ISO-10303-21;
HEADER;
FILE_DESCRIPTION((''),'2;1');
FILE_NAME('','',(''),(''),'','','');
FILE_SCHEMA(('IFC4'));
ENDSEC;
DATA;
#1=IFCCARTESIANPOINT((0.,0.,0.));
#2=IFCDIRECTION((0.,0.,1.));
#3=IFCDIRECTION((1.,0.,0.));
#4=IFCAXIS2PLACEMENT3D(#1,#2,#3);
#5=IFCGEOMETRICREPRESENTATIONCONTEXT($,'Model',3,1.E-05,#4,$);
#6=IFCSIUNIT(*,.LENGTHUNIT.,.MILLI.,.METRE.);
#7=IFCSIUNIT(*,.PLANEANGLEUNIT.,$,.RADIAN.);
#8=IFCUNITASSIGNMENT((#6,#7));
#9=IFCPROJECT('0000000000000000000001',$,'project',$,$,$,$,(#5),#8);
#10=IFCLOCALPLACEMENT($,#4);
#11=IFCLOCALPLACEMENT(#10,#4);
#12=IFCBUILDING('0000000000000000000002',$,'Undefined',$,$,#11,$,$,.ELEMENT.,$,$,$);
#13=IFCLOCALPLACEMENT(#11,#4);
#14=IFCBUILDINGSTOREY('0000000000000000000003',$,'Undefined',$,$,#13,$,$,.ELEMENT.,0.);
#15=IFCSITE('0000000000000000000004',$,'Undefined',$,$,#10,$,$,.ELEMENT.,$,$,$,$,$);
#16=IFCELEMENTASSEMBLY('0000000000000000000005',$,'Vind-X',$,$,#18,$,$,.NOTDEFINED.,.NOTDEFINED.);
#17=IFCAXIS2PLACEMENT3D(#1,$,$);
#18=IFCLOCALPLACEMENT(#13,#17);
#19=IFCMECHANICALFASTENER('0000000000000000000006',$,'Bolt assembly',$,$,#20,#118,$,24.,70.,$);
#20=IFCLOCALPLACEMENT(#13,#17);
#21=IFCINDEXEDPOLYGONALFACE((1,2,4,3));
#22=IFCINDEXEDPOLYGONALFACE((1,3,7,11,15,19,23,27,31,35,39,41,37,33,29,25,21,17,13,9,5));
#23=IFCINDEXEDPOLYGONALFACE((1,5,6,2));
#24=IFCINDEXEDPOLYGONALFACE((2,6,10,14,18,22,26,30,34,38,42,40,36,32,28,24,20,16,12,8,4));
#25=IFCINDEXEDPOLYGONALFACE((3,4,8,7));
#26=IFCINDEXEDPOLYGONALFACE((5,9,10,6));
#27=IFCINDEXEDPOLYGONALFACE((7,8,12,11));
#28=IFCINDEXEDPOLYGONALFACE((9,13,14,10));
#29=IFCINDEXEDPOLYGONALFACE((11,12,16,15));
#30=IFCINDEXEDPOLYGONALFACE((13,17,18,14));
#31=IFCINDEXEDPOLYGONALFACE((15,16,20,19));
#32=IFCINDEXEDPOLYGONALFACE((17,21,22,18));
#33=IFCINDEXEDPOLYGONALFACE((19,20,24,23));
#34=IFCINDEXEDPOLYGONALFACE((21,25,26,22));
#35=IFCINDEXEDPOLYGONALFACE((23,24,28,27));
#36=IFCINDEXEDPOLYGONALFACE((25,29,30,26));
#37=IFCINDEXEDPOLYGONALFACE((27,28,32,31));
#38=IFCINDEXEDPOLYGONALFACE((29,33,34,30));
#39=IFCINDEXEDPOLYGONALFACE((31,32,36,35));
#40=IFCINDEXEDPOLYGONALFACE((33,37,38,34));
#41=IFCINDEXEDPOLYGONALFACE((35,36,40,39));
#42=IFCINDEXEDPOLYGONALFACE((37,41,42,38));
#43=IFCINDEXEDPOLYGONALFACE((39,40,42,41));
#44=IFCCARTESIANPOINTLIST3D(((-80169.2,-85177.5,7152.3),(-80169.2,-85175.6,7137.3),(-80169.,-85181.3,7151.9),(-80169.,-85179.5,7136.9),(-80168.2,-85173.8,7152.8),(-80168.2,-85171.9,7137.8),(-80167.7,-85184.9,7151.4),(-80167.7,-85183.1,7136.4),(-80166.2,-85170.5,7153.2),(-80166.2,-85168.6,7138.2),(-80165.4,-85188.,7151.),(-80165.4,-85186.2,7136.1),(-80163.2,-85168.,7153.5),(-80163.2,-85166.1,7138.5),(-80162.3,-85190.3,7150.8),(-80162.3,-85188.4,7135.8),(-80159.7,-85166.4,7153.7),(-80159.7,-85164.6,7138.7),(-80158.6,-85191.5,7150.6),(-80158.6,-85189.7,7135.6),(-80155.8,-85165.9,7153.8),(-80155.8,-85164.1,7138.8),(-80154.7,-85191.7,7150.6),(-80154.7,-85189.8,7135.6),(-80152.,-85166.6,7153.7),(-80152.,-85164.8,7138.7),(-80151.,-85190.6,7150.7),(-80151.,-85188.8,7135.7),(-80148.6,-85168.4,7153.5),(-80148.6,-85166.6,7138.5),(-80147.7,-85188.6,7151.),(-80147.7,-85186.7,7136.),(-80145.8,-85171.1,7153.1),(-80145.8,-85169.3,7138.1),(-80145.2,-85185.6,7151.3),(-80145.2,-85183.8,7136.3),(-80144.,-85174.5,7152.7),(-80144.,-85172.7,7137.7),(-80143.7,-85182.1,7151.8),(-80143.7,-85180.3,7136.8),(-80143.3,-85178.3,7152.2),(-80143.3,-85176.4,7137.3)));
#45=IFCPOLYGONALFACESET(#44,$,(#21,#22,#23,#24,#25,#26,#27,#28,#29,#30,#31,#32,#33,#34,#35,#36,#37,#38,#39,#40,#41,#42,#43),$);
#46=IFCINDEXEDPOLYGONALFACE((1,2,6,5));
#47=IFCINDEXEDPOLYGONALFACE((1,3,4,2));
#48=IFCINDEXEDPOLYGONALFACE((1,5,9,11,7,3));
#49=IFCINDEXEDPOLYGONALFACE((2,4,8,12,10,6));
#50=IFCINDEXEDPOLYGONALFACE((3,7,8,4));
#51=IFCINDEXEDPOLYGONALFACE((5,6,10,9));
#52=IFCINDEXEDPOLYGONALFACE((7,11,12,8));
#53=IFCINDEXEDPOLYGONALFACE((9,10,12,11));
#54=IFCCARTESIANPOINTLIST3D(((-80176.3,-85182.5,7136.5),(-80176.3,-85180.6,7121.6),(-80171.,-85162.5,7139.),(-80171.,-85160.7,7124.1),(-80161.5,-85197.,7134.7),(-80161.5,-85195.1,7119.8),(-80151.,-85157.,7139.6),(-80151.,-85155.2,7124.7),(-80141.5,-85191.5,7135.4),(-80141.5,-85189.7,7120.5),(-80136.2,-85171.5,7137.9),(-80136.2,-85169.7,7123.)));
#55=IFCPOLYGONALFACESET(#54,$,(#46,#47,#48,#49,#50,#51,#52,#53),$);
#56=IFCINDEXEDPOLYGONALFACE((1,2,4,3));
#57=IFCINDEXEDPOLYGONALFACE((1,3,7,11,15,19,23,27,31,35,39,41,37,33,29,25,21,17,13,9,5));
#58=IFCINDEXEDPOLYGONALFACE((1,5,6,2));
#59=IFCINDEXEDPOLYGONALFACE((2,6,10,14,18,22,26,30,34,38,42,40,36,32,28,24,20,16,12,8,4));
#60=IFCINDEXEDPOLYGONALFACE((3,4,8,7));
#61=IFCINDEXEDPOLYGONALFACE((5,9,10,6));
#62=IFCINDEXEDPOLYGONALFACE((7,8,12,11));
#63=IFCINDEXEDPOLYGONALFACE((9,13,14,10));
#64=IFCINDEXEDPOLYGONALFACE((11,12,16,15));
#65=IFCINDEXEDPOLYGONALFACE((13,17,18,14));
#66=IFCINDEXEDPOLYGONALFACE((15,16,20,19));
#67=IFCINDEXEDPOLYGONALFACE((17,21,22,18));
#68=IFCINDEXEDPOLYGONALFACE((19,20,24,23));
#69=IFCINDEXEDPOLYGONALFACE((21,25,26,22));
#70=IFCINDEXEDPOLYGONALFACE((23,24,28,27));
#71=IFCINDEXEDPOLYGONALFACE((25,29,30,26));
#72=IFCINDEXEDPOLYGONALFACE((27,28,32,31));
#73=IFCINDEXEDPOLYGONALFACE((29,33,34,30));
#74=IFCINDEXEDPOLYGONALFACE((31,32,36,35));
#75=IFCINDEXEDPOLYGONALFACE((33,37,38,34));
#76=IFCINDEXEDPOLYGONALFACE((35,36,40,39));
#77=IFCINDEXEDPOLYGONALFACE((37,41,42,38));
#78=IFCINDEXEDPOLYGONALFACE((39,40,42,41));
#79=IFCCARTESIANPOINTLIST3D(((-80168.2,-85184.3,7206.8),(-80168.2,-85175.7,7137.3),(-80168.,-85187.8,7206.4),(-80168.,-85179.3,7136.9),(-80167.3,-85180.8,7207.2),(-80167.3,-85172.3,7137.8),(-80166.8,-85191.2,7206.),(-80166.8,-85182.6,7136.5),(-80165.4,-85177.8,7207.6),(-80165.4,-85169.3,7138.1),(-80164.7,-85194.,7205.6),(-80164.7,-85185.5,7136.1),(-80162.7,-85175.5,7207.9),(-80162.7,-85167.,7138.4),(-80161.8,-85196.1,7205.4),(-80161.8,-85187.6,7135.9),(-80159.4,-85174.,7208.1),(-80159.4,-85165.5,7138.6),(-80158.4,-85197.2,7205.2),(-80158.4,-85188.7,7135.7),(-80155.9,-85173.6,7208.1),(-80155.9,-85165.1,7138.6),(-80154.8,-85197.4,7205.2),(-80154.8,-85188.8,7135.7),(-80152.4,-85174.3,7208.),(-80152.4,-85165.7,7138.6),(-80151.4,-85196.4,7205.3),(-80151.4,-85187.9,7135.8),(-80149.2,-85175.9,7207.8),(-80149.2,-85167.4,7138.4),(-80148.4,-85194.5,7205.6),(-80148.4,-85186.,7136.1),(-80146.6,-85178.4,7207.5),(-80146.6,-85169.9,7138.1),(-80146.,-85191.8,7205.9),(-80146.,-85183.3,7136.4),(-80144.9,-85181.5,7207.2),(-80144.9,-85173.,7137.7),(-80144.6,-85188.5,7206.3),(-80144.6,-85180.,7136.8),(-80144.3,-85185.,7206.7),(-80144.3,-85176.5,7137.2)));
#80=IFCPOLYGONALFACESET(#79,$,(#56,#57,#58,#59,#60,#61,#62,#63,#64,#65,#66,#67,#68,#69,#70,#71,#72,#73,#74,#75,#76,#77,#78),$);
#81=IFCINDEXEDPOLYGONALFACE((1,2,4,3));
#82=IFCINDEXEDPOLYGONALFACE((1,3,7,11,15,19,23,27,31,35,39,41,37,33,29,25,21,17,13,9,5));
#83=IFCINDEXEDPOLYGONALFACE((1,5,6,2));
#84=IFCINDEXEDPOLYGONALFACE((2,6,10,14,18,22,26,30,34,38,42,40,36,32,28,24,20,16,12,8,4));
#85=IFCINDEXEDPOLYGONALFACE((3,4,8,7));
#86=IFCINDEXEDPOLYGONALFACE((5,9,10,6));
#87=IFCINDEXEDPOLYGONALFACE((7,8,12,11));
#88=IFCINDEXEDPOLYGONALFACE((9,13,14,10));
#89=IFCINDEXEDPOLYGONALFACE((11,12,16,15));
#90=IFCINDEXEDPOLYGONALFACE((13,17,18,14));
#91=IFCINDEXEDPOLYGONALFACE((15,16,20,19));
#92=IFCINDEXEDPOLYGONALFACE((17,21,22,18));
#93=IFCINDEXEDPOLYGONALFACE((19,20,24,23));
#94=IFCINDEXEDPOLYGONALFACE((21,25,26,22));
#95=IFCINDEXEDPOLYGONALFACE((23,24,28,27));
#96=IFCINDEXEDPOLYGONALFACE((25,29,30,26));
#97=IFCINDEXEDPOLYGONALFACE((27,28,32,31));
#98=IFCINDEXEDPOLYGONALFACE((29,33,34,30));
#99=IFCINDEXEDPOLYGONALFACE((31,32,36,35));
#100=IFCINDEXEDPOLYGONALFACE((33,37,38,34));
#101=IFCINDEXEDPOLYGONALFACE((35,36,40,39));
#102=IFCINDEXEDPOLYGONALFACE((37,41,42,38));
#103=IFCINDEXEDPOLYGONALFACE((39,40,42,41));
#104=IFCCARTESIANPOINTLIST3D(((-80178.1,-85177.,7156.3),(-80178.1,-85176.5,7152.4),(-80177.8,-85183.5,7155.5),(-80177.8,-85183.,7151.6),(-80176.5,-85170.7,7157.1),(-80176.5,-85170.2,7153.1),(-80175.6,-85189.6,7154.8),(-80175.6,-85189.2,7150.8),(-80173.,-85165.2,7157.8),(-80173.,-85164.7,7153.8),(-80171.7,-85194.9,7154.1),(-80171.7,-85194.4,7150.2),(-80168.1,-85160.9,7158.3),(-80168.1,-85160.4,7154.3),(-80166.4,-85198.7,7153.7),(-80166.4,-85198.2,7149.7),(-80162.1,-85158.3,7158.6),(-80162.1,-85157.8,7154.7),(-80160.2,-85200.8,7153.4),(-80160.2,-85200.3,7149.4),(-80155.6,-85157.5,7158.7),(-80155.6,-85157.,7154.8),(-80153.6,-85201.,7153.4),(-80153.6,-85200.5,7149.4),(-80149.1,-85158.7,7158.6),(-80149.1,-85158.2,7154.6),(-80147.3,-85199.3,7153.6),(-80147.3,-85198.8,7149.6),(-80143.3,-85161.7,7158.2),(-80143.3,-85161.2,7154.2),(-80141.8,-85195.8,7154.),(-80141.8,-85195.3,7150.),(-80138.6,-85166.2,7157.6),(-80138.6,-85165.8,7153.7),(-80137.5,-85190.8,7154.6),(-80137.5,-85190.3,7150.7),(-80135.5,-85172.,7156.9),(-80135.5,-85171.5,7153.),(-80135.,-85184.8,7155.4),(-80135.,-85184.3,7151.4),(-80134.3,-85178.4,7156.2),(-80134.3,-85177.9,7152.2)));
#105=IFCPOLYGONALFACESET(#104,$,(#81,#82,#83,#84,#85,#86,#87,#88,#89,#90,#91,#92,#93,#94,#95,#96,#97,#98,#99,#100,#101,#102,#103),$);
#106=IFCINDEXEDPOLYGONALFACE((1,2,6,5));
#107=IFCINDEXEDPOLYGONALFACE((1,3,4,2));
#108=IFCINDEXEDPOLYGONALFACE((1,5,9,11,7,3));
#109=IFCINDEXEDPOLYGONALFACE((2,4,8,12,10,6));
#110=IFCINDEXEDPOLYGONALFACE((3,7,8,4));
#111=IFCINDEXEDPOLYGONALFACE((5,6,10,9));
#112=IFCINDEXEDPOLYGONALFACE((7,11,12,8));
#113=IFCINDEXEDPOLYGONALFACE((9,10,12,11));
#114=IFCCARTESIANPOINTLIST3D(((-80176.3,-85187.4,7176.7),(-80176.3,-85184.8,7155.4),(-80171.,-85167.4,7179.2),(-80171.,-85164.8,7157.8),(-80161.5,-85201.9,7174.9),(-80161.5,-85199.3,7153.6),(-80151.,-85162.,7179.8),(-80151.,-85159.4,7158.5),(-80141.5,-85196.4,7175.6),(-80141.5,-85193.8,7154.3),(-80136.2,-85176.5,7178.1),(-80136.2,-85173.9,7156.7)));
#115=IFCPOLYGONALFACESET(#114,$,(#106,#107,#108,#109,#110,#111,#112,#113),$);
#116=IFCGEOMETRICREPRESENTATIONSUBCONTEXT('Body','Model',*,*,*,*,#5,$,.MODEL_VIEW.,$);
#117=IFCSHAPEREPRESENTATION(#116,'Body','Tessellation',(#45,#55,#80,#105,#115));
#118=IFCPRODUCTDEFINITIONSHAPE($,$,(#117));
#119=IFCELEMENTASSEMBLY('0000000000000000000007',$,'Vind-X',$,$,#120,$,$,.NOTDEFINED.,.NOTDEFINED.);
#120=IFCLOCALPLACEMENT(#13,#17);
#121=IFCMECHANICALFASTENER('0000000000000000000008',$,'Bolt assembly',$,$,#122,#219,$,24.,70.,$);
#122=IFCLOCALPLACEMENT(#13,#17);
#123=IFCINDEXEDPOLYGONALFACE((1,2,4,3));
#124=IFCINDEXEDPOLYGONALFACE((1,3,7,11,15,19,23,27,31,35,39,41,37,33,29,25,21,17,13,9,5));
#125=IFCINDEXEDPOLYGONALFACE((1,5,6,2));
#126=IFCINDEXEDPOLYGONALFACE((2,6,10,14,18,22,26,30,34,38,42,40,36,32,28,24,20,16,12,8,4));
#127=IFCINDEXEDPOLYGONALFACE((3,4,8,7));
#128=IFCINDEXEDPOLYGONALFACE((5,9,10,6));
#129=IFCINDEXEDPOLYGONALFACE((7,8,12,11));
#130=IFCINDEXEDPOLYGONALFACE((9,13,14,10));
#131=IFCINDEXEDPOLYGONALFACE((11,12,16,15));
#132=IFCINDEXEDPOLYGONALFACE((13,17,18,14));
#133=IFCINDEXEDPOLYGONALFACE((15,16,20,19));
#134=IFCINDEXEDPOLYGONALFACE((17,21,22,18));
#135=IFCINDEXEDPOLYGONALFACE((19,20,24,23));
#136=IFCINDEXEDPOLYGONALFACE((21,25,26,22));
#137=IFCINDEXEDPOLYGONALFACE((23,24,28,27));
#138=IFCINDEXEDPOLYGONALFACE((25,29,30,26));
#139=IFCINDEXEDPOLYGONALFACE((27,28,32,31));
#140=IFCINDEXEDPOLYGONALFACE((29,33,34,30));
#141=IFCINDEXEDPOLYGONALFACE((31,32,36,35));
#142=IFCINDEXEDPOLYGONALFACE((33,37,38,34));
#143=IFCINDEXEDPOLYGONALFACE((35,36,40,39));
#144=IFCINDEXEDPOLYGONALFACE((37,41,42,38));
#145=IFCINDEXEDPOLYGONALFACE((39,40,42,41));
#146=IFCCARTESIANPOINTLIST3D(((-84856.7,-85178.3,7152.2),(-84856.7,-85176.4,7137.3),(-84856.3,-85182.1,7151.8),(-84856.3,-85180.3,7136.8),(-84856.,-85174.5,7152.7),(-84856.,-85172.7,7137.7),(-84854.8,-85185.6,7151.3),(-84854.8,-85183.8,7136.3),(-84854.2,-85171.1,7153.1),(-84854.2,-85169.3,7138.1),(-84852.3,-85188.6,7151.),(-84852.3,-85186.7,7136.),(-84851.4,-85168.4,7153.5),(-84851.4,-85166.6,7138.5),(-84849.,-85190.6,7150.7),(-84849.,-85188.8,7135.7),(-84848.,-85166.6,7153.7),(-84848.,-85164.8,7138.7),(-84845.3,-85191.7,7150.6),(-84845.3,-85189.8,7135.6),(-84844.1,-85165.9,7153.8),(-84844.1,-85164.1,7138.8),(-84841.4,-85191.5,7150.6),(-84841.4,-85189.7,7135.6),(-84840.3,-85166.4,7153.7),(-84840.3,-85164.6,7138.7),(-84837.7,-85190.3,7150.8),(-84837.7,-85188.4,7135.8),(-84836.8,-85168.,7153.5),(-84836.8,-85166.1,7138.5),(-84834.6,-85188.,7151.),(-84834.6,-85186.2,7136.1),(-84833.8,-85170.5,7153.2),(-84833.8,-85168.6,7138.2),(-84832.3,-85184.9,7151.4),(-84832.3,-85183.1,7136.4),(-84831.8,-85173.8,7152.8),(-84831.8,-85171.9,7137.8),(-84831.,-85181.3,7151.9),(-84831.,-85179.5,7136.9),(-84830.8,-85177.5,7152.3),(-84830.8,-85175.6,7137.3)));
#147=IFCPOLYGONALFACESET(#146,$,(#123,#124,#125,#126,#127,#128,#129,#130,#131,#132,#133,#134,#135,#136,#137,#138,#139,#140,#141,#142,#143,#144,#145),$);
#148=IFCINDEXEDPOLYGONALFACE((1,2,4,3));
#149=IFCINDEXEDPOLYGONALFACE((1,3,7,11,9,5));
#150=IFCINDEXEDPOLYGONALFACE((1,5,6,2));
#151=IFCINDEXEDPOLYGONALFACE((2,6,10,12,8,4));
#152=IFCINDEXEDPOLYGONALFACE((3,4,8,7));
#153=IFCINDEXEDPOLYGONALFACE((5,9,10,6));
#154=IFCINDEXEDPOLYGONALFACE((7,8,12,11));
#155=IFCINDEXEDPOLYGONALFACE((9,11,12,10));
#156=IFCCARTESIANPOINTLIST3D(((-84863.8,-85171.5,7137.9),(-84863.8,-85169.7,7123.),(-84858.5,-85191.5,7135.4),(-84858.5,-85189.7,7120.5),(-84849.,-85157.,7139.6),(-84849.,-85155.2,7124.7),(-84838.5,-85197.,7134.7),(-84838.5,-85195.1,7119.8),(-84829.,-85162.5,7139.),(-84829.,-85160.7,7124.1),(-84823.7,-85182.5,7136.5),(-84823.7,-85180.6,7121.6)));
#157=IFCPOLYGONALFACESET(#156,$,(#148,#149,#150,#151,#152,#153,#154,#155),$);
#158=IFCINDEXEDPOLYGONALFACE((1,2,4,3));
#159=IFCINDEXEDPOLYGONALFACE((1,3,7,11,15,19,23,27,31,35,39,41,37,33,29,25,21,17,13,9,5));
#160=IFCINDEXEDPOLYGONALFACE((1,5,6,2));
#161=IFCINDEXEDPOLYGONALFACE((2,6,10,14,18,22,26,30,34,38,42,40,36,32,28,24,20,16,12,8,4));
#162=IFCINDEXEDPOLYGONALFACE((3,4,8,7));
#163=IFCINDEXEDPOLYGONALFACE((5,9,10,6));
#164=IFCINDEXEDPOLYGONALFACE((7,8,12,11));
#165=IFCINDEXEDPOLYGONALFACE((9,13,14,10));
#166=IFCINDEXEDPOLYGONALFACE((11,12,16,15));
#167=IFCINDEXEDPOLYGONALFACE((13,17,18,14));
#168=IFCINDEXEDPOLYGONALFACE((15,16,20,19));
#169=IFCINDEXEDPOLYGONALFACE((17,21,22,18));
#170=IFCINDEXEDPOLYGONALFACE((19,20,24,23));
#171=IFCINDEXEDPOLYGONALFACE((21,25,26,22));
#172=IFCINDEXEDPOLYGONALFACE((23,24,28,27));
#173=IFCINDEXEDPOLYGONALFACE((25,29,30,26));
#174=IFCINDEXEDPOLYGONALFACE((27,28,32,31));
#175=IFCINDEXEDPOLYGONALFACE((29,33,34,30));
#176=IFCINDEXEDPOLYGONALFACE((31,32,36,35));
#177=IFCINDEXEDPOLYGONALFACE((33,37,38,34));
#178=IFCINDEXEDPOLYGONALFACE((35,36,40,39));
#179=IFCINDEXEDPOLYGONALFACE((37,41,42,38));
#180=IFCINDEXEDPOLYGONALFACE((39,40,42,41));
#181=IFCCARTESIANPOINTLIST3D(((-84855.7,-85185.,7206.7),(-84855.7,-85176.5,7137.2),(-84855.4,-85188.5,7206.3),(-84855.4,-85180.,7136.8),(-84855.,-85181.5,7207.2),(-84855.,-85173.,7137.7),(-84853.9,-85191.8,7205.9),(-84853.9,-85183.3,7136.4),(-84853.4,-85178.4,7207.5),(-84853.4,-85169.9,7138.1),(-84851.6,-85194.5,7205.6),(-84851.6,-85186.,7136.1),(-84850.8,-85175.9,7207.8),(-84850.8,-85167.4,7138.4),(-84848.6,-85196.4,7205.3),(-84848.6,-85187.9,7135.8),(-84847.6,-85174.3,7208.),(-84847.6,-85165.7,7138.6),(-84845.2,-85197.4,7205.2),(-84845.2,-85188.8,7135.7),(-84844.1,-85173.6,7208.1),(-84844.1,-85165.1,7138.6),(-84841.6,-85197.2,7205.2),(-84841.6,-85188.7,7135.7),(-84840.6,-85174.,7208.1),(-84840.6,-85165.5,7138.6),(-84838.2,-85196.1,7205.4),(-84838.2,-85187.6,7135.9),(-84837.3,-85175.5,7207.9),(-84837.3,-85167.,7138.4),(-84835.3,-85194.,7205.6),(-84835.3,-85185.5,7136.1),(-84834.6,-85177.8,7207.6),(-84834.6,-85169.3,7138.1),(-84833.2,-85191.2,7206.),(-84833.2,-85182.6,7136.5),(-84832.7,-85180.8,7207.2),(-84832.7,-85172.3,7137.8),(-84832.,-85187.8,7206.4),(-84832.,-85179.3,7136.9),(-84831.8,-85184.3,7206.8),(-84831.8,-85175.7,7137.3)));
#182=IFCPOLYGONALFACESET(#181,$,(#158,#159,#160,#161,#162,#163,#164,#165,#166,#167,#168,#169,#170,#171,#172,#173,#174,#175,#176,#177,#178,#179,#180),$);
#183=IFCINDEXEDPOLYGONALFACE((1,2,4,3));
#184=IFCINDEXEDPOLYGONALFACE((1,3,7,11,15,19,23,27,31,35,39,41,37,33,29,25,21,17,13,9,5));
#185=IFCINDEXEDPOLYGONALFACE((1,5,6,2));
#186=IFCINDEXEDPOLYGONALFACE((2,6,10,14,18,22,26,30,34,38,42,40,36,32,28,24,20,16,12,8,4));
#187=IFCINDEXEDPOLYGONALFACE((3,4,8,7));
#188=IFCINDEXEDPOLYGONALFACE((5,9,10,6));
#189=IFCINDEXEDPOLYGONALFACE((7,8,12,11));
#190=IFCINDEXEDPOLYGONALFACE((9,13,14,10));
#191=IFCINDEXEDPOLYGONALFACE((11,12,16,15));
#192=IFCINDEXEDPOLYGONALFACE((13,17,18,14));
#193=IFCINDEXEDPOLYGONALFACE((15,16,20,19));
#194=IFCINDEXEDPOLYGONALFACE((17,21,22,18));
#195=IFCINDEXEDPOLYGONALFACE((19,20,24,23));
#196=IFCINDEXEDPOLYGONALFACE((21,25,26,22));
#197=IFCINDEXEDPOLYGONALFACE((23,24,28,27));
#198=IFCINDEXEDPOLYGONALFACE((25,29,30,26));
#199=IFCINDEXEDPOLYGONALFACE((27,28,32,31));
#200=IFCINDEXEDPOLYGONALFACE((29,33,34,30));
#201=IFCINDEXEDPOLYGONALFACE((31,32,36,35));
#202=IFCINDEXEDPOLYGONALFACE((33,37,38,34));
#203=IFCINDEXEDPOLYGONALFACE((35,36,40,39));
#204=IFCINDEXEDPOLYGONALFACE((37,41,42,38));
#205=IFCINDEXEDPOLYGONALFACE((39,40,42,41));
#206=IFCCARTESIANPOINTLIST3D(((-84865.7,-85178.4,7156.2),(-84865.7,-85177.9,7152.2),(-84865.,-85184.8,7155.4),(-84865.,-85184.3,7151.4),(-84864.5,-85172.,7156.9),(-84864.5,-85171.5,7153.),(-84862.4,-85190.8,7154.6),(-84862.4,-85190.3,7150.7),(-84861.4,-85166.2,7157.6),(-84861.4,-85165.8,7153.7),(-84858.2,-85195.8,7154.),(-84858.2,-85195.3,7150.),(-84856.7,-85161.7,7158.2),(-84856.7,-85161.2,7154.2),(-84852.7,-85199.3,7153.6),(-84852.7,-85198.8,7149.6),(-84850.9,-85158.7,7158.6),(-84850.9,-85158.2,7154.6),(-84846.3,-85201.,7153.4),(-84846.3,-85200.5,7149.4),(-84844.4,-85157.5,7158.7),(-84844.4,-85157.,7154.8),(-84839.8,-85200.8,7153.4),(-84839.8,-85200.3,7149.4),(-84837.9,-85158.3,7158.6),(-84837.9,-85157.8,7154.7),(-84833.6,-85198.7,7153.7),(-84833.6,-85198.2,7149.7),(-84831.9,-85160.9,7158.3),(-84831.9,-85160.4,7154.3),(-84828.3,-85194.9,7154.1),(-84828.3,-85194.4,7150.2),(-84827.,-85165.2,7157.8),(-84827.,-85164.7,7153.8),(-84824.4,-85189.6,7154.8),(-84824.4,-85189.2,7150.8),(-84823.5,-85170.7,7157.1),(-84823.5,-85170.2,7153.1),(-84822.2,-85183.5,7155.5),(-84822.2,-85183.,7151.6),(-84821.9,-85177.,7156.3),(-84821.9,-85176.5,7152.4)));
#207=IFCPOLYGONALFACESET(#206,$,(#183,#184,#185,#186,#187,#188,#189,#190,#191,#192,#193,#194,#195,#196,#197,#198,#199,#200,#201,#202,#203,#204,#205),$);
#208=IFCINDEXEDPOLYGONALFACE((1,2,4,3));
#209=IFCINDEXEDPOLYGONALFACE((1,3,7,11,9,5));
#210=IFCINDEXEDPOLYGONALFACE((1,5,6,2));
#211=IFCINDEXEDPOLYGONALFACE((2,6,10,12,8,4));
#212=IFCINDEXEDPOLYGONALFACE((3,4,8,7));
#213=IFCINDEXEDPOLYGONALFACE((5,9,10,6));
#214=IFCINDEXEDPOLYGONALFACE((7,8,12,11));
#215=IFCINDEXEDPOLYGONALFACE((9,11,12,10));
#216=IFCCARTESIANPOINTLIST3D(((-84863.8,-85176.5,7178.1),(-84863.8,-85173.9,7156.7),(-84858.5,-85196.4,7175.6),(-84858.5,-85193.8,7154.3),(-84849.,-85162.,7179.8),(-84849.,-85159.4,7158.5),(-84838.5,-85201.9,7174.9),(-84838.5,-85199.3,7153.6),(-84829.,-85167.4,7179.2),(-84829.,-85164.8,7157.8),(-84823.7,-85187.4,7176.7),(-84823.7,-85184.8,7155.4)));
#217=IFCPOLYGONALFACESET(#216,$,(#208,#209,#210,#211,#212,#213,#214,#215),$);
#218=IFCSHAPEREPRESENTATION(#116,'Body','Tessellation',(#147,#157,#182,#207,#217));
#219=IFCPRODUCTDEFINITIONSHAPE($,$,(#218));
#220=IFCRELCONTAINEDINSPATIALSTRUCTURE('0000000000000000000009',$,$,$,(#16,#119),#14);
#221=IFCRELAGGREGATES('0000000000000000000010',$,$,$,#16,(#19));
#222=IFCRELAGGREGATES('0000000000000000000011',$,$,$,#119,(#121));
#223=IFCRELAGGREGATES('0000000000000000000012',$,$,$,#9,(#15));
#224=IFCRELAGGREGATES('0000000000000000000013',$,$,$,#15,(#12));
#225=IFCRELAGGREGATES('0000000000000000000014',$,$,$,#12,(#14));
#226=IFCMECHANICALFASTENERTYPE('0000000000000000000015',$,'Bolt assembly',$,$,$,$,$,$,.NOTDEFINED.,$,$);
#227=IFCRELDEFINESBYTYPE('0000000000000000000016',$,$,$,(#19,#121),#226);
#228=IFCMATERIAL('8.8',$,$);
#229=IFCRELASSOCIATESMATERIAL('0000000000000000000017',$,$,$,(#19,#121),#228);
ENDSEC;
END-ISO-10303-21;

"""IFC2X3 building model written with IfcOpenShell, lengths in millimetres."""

from ifc_helpers import new_model, si_unit, frame, origin_with_axes, origin_2d_with_axis, place, context, subcontext, project, spatial, polyline, circle, outline, extrude, source, transform, mapped, material, type_object, element, aggregate, save


model = new_model("IFC2X3")

# Units and contexts
model_context = context("Model", 3, precision=1e-05, world=origin_with_axes())
body_context = subcontext(model_context, "Body", "Model", "MODEL_VIEW")
ifc_project = project(units=[si_unit("LENGTHUNIT", "METRE", prefix="MILLI"), si_unit("PLANEANGLEUNIT", "RADIAN")], contexts=[model_context])

# Site, building, storey
site_placement = place(None, origin_with_axes())
site = spatial("IfcSite", under=ifc_project, at=site_placement, Name="Undefined", CompositionType="ELEMENT")
building_placement = place(site_placement, origin_with_axes())
building = spatial("IfcBuilding", under=site, at=building_placement, Name="Undefined", CompositionType="ELEMENT")
storey_placement = place(building_placement, origin_with_axes())
storey = spatial("IfcBuildingStorey", under=building, at=storey_placement, Name="Undefined", CompositionType="ELEMENT", Elevation=0.0)

# Element assembly
assembly_1_placement = place(storey_placement, origin_with_axes())
assembly_1 = element("IfcElementAssembly", 1, at=assembly_1_placement, inside=storey, Name="Vind-X", AssemblyPlace="NOTDEFINED", PredefinedType="NOTDEFINED")

# Mechanical fastener
ifc_material_1 = material(Name="8.8")
mechanical_fastener_type = type_object("IfcMechanicalFastenerType", Name="Bolt assembly")
shared_shape_1 = source(origin_with_axes(), body_context, "Body", "SweptSolid", [
    extrude(circle(Radius=13.0, at=origin_2d_with_axis()), frame((0.0, 0.0, 0.0), z_axis=(0.0, 1.0, 0.0), x_axis=(1.0, 0.0, 0.0)), (0.0, 0.0, 1.0), 15.1),
    extrude(outline(polyline([(18.0, -10.4), (18.0, 10.4), (0.0, 20.8), (-18.0, 10.4), (-18.0, -10.4), (0.0, -20.8), (18.0, -10.4)])), frame((0.0, -15.0, 0.0), z_axis=(0.0, 1.0, 0.0), x_axis=(1.0, 0.0, 0.0)), (0.0, 0.0, 1.0), 15.0),
    extrude(circle(Radius=12.0, at=origin_2d_with_axis()), frame((0.0, 0.0, 0.0), z_axis=(0.0, 1.0, 0.0), x_axis=(1.0, 0.0, 0.0)), (0.0, 0.0, 1.0), 70.0),
    extrude(circle(Radius=22.0, at=origin_2d_with_axis()), frame((0.0, 15.0, 0.0), z_axis=(0.0, 1.0, 0.0), x_axis=(1.0, 0.0, 0.0)), (0.0, 0.0, 1.0), 4.0),
    extrude(outline(polyline([(18.0, -10.4), (18.0, 10.4), (0.0, 20.8), (-18.0, 10.4), (-18.0, -10.4), (0.0, -20.8), (18.0, -10.4)])), frame((0.0, 19.0, 0.0), z_axis=(0.0, 1.0, 0.0), x_axis=(1.0, 0.0, 0.0)), (0.0, 0.0, 1.0), 21.5),
])
mechanical_fastener_1_placement = place(assembly_1_placement, frame((-80156.3, -85177.0, 7137.2), z_axis=(-0.711592, 0.697356, 0.085625), x_axis=(-0.702593, -0.706288, -0.086721)))
mechanical_fastener_1 = element("IfcMechanicalFastener", 2, at=mechanical_fastener_1_placement, type_object=mechanical_fastener_type, material=ifc_material_1, Name="Bolt assembly", NominalDiameter=24.0, NominalLength=70.0, context=body_context, shape_type="MappedRepresentation", body=[
    mapped(shared_shape_1, transform((0.0, 0.0, 0.0))),
])
aggregate(assembly_1, [mechanical_fastener_1])

# Element assembly, mechanical fastener
assembly_2_placement = place(storey_placement, origin_with_axes())
assembly_2 = element("IfcElementAssembly", 3, at=assembly_2_placement, inside=storey, Name="Vind-X", AssemblyPlace="NOTDEFINED", PredefinedType="NOTDEFINED")
mechanical_fastener_2_placement = place(assembly_2_placement, frame((-84843.7, -85177.0, 7137.2), z_axis=(-0.711592, -0.697356, -0.085625), x_axis=(0.702593, -0.706288, -0.086721)))
mechanical_fastener_2 = element("IfcMechanicalFastener", 4, at=mechanical_fastener_2_placement, type_object=mechanical_fastener_type, material=ifc_material_1, Name="Bolt assembly", NominalDiameter=24.0, NominalLength=70.0, context=body_context, shape_type="MappedRepresentation", body=[
    mapped(shared_shape_1, transform((0.0, 0.0, 0.0))),
])
aggregate(assembly_2, [mechanical_fastener_2])

save(model, "model.ifc")
